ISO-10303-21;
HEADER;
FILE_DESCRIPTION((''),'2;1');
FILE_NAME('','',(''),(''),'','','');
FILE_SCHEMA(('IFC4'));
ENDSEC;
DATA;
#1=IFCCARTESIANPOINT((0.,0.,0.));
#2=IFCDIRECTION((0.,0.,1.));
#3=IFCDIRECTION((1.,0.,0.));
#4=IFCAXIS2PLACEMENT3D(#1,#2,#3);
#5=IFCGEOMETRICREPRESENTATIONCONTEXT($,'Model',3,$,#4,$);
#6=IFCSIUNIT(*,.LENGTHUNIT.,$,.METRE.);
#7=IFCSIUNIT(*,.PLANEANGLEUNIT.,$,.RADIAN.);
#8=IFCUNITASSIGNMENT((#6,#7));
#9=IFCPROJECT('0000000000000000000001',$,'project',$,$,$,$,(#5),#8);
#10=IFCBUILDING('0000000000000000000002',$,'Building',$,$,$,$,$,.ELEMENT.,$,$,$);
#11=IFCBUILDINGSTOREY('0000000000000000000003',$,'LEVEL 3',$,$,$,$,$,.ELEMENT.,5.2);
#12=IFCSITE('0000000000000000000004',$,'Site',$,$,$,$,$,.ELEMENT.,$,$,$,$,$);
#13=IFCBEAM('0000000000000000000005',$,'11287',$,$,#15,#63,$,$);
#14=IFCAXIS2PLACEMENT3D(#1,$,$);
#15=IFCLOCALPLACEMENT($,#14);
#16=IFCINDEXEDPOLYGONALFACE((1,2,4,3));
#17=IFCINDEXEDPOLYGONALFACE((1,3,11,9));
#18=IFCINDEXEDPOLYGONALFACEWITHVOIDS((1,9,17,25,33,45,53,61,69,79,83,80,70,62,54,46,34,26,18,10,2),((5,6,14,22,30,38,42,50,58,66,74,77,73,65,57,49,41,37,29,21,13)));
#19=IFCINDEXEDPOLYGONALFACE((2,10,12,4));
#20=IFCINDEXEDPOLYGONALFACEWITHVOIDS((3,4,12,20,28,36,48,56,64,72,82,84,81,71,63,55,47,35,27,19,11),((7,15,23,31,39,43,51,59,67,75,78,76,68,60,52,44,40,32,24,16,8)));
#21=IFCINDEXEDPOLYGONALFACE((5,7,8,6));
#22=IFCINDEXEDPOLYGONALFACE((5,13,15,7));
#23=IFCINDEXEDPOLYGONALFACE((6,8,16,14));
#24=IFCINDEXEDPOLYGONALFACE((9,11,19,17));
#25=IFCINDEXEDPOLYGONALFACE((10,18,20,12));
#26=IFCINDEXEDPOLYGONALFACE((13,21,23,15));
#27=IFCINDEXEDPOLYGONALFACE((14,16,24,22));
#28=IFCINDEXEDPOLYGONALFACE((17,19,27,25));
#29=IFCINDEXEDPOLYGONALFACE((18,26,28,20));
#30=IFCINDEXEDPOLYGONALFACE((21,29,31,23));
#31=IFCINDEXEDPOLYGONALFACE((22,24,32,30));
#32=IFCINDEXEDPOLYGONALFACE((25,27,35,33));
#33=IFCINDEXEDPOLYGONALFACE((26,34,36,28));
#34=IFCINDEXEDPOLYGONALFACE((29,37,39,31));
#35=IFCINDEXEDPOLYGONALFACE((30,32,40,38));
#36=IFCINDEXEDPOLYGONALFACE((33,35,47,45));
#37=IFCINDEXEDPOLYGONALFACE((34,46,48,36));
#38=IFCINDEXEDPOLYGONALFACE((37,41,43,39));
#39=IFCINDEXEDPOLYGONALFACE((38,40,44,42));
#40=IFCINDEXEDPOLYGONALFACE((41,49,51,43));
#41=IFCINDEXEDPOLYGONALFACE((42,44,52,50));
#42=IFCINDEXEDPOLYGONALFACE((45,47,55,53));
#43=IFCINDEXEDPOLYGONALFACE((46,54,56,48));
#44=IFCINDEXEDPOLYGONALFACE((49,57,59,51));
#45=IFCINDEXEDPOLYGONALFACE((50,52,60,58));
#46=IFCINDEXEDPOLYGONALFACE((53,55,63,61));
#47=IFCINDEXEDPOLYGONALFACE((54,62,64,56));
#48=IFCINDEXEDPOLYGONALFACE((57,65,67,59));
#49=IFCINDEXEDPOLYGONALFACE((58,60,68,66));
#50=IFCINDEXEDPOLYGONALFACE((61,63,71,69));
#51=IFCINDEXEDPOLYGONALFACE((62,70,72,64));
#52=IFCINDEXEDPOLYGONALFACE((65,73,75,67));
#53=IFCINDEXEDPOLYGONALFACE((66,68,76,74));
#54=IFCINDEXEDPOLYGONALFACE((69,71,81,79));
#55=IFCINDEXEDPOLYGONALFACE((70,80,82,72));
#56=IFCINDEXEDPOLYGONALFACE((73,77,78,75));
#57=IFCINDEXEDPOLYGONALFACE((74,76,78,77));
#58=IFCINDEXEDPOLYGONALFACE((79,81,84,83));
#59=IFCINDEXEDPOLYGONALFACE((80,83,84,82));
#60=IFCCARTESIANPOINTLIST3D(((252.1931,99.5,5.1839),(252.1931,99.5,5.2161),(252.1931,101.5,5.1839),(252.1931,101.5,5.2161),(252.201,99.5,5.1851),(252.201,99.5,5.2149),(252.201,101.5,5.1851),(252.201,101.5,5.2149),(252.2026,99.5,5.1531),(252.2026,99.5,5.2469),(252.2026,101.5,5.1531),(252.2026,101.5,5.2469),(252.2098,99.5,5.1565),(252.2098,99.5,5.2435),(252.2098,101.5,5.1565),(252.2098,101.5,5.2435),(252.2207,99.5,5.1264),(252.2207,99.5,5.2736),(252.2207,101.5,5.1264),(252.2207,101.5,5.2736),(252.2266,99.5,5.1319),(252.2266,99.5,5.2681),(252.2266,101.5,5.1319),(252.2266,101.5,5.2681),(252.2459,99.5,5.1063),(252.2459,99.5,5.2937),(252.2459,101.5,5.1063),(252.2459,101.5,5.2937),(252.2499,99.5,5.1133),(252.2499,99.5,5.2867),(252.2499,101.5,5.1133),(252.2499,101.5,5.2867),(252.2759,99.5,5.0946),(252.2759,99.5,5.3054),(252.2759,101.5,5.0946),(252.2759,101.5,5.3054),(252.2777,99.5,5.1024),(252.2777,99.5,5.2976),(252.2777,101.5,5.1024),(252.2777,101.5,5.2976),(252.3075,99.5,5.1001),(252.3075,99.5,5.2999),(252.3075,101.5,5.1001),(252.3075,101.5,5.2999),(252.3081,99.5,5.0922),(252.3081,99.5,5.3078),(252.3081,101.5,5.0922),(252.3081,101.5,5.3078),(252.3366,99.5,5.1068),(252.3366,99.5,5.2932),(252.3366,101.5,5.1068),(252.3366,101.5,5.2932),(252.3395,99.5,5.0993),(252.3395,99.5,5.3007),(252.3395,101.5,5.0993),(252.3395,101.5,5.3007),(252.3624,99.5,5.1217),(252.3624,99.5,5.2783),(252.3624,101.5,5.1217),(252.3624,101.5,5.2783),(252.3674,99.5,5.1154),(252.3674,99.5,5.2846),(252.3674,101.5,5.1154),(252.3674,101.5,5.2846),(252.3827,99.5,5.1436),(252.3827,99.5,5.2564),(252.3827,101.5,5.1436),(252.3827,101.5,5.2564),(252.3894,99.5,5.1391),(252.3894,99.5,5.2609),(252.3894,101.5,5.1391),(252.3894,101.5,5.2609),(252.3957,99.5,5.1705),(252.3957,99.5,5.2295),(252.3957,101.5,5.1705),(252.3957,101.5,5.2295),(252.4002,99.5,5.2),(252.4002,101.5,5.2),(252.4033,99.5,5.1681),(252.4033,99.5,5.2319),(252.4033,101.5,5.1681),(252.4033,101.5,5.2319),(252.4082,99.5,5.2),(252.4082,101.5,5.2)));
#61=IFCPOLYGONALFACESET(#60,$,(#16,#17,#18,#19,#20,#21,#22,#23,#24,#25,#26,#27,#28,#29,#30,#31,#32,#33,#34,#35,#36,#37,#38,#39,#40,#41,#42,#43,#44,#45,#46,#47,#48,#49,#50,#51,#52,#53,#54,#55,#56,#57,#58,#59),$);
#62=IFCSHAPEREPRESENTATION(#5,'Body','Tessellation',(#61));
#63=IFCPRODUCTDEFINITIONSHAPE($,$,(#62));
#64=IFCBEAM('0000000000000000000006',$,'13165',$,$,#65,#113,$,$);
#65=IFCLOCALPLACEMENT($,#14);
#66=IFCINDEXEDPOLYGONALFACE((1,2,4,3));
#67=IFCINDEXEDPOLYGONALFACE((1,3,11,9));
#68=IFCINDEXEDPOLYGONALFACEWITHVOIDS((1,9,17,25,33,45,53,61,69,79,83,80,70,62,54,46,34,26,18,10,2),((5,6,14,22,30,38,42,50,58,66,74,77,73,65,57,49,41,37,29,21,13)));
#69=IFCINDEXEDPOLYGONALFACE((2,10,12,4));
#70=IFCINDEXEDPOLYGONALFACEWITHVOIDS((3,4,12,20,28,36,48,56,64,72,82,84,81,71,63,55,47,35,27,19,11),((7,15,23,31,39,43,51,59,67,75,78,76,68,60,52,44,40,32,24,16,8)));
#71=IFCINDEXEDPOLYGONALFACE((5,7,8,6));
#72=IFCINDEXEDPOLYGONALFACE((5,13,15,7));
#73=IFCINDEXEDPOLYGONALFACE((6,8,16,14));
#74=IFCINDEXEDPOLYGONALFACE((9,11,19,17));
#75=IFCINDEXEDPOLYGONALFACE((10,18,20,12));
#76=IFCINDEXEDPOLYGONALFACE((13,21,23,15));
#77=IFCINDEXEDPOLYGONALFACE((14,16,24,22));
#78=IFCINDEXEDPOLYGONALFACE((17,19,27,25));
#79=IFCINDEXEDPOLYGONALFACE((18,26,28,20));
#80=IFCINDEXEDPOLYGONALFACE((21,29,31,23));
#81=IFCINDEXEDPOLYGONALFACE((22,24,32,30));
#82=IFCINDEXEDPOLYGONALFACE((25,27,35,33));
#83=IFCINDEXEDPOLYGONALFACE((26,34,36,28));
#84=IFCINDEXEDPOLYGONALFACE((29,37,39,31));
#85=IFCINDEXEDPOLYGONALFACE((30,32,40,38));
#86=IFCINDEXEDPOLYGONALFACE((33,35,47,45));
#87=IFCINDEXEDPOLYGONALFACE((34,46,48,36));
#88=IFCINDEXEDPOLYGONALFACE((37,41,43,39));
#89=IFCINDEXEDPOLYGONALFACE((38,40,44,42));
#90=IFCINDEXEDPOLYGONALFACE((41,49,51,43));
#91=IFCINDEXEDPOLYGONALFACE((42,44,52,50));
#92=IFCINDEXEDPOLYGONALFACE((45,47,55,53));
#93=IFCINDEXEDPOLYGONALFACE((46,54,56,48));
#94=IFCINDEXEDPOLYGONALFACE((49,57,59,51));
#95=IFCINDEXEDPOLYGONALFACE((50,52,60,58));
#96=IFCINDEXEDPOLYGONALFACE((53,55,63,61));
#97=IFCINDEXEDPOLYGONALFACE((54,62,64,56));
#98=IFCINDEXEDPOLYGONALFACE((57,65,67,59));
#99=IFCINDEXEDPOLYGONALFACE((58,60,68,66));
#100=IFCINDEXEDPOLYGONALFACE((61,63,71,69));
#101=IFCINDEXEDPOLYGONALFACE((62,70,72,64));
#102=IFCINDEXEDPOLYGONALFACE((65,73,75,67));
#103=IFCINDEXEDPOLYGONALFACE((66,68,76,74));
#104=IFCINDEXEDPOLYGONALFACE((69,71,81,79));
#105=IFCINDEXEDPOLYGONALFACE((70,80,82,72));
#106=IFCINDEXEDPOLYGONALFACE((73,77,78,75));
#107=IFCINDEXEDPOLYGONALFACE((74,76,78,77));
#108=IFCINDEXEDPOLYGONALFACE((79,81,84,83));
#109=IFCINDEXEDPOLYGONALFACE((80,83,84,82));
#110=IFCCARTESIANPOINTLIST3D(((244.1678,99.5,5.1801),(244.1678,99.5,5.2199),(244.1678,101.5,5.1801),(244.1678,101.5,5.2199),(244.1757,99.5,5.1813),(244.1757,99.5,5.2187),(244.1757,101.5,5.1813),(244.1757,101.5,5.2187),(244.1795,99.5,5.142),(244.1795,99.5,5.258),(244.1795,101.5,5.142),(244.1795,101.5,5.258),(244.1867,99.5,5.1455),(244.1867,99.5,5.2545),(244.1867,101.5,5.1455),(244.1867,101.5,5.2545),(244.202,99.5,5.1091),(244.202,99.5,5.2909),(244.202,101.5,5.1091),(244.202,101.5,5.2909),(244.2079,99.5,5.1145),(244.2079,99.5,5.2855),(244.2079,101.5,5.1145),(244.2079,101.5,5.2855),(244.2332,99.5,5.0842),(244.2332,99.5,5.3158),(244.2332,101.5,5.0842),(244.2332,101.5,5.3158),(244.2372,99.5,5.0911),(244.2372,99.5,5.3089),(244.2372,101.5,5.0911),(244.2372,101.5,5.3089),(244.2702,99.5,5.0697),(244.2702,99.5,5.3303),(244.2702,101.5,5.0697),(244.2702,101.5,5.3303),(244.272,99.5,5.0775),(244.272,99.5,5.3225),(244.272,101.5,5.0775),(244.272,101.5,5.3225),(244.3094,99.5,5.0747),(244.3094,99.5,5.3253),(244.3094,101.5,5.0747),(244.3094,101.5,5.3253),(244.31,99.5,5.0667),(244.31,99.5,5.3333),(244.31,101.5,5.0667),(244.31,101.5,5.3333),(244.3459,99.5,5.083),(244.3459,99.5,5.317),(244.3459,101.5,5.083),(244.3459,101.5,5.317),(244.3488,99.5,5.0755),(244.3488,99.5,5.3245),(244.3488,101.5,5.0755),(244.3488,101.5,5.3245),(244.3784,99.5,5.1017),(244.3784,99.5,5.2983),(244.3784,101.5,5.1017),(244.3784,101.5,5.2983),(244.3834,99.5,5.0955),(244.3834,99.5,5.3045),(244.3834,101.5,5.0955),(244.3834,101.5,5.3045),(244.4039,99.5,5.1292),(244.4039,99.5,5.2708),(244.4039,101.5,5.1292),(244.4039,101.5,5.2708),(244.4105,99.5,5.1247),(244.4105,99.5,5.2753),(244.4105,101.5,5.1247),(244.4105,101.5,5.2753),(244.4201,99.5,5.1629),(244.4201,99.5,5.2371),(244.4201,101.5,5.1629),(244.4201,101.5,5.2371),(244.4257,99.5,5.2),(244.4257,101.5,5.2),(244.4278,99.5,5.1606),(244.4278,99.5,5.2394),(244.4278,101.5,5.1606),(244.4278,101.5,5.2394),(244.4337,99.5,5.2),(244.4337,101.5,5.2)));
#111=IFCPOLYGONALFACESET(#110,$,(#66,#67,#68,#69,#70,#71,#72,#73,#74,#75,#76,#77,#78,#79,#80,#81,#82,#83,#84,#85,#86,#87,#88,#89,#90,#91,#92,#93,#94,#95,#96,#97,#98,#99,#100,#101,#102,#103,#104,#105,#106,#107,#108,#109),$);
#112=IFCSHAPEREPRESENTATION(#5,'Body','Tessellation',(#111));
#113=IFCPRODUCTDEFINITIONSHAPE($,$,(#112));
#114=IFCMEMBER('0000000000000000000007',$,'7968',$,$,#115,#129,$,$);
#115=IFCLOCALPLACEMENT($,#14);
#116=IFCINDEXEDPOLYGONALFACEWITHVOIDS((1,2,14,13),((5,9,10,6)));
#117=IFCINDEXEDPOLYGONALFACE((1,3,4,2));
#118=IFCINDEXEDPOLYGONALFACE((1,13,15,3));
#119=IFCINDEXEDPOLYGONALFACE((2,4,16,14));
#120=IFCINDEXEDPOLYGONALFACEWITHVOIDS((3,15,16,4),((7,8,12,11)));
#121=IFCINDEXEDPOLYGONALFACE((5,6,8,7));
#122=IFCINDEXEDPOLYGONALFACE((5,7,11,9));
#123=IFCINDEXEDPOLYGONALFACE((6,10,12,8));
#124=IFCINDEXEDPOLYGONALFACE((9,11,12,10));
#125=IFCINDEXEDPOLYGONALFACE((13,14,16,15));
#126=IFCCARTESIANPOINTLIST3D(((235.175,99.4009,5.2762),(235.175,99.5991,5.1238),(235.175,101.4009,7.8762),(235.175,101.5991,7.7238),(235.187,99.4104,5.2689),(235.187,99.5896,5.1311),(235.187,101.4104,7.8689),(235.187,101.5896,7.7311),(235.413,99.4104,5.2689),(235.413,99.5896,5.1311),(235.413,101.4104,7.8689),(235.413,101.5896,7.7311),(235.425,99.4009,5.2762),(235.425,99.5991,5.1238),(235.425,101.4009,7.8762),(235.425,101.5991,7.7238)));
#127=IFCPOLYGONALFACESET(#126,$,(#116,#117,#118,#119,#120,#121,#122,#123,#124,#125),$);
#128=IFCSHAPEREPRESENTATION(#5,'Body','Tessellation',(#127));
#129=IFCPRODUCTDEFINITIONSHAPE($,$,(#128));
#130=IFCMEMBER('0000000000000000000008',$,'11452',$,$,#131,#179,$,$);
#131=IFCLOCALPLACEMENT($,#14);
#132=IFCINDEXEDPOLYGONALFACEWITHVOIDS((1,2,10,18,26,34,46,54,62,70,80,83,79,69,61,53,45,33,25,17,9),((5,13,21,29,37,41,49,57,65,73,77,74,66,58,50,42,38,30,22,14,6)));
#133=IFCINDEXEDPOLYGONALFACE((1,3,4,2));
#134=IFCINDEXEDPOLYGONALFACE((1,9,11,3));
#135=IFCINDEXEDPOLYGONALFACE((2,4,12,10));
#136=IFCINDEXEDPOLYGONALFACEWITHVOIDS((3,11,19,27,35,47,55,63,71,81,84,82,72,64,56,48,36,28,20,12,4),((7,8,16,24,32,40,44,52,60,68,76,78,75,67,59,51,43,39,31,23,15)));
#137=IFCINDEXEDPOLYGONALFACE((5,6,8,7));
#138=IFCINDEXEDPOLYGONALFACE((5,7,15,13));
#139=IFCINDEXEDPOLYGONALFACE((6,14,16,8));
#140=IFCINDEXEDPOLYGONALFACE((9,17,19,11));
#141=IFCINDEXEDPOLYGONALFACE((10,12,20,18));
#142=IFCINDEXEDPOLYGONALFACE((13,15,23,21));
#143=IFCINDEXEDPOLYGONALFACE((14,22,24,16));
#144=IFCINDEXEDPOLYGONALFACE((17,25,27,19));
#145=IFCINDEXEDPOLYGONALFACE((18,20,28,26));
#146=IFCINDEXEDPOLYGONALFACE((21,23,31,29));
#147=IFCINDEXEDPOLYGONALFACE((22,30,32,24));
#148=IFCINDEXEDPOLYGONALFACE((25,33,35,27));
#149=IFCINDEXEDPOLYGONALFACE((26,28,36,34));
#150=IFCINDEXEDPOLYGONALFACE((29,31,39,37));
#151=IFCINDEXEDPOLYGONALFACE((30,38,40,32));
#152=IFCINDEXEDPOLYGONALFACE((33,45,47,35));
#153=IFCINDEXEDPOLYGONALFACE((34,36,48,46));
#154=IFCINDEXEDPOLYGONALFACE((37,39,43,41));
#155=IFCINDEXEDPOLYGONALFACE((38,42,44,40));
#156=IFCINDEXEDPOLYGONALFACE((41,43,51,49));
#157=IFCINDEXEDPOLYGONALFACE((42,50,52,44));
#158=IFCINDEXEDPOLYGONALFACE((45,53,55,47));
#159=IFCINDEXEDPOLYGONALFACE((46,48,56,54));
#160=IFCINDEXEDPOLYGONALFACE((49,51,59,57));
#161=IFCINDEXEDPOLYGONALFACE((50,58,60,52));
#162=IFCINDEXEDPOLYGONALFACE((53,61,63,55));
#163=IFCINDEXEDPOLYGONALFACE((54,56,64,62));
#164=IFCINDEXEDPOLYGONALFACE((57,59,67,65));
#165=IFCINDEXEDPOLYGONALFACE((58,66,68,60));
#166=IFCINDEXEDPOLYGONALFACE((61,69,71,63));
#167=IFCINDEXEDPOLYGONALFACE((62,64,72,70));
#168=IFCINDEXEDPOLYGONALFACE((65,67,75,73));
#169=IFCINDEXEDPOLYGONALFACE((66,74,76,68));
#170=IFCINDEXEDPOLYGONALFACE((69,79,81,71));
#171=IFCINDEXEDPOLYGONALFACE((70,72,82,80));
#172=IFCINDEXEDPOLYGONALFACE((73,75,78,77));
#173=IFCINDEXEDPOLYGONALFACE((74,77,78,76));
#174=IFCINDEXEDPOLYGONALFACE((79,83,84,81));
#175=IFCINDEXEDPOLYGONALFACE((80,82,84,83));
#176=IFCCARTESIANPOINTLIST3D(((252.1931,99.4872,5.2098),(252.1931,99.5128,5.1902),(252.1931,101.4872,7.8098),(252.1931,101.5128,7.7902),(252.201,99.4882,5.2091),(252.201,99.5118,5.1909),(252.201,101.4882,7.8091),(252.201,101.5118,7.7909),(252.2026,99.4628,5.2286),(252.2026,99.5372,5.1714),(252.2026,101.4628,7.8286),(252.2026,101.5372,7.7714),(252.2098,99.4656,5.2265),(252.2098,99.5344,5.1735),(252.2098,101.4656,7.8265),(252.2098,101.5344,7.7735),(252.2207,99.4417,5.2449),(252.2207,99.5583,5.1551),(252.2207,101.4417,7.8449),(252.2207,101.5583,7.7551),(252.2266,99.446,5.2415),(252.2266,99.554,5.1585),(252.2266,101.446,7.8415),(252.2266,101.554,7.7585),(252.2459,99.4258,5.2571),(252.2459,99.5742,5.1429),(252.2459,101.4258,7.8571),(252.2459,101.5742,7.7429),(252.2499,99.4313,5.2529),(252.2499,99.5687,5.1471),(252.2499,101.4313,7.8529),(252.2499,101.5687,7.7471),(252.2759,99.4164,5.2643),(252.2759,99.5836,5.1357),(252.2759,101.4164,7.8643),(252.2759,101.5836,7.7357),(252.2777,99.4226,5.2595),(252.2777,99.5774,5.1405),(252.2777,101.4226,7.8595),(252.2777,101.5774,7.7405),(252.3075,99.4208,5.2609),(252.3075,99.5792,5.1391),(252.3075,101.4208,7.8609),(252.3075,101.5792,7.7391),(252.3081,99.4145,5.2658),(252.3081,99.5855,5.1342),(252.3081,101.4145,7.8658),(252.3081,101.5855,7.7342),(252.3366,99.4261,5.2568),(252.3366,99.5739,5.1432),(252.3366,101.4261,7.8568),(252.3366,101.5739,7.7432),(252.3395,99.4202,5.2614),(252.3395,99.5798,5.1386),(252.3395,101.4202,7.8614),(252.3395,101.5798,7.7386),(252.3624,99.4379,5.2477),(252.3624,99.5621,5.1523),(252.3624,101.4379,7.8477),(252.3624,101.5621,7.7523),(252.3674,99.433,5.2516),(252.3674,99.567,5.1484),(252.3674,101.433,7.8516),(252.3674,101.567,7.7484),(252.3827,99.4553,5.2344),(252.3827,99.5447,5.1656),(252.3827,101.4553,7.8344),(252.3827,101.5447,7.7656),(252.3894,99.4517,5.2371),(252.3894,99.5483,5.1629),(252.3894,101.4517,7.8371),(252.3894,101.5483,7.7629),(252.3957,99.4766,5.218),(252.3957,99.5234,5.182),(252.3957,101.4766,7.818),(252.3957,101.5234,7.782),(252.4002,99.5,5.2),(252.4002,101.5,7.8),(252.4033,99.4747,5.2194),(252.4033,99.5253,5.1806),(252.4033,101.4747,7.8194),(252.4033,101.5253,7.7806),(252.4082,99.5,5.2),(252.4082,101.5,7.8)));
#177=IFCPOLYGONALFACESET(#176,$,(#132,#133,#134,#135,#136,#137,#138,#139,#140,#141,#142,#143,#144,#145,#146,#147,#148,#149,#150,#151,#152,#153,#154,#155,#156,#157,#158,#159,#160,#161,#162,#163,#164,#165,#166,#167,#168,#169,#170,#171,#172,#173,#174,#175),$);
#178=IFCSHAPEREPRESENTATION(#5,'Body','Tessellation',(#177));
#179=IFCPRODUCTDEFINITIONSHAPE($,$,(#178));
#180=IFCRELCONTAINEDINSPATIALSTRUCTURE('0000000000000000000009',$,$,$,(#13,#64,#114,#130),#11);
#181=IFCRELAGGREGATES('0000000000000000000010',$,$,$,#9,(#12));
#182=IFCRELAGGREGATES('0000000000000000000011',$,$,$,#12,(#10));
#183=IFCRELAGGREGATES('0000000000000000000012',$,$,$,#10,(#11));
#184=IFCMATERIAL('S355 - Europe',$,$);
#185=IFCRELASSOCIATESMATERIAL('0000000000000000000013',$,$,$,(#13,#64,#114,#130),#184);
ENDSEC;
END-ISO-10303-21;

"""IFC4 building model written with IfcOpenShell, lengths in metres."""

from ifc_helpers import new_model, si_unit, frame, origin_with_axes, origin_2d_with_axis, place, context, project, spatial, hollow_rectangle, hollow_circle, extrude, material, material_profile, profile_set, profile_usage, element, save


model = new_model("IFC4")

# Units and contexts
model_context = context("Model", 3, world=origin_with_axes())
ifc_project = project(units=[si_unit("LENGTHUNIT", "METRE"), si_unit("PLANEANGLEUNIT", "RADIAN")], contexts=[model_context])

# Site, building, storey
site = spatial("IfcSite", under=ifc_project, Name="Site", CompositionType="ELEMENT")
building = spatial("IfcBuilding", under=site, Name="Building", CompositionType="ELEMENT")
storey = spatial("IfcBuildingStorey", under=building, Name="LEVEL 3", CompositionType="ELEMENT", Elevation=5.2)

# Shared definitions
ifc_material = material(Name="S355 - Europe")

# Beams
ifc_material_profile_1 = material_profile(ifc_material, hollow_circle(Radius=0.1081, WallThickness=0.008, at=origin_2d_with_axis()))
ifc_profile_set_1 = profile_set([ifc_material_profile_1])
ifc_profile_usage_1 = profile_usage(ifc_profile_set_1, cardinal=10)
beam_1_placement = place(None, frame((252.3, 101.5, 5.2), z_axis=(0.0, -1.0, 0.0), x_axis=(1.0, 0.0, 0.0)))
element("IfcBeam", 1, at=beam_1_placement, inside=storey, material=ifc_profile_usage_1, Name="11287", context=model_context, shape_type="SweptSolid", body=[
    extrude(hollow_circle(Radius=0.1081, WallThickness=0.008, at=origin_2d_with_axis()), origin_with_axes(), (0.0, 0.0, 1.0), 2.0),
])
ifc_material_profile_2 = material_profile(ifc_material, hollow_circle(Radius=0.1337, WallThickness=0.008, at=origin_2d_with_axis()))
ifc_profile_set_2 = profile_set([ifc_material_profile_2])
ifc_profile_usage_2 = profile_usage(ifc_profile_set_2, cardinal=10)
beam_2_placement = place(None, frame((244.3, 101.5, 5.2), z_axis=(0.0, -1.0, 0.0), x_axis=(1.0, 0.0, 0.0)))
element("IfcBeam", 2, at=beam_2_placement, inside=storey, material=ifc_profile_usage_2, Name="13165", context=model_context, shape_type="SweptSolid", body=[
    extrude(hollow_circle(Radius=0.1337, WallThickness=0.008, at=origin_2d_with_axis()), origin_with_axes(), (0.0, 0.0, 1.0), 2.0),
])

# Members
ifc_material_profile_3 = material_profile(ifc_material, hollow_rectangle(XDim=0.25, YDim=0.25, WallThickness=0.012, at=origin_2d_with_axis()))
ifc_profile_set_3 = profile_set([ifc_material_profile_3])
ifc_profile_usage_3 = profile_usage(ifc_profile_set_3, cardinal=10)
member_1_placement = place(None, frame((235.3, 101.5, 7.8), z_axis=(0.0, -0.609711, -0.792624), x_axis=(1.0, 0.0, 0.0)))
element("IfcMember", 3, at=member_1_placement, inside=storey, material=ifc_profile_usage_3, Name="7968", context=model_context, shape_type="SweptSolid", body=[
    extrude(hollow_rectangle(XDim=0.25, YDim=0.25, WallThickness=0.012, at=origin_2d_with_axis()), origin_with_axes(), (0.0, 0.0, 1.0), 3.2802),
])
ifc_material_profile_4 = material_profile(ifc_material, hollow_circle(Radius=0.1081, WallThickness=0.008, at=origin_2d_with_axis()))
ifc_profile_set_4 = profile_set([ifc_material_profile_4])
ifc_profile_usage_4 = profile_usage(ifc_profile_set_4, cardinal=10)
member_2_placement = place(None, frame((252.3, 101.5, 7.8), z_axis=(0.0, -0.609711, -0.792624), x_axis=(1.0, 0.0, 0.0)))
element("IfcMember", 4, at=member_2_placement, inside=storey, material=ifc_profile_usage_4, Name="11452", context=model_context, shape_type="SweptSolid", body=[
    extrude(hollow_circle(Radius=0.1081, WallThickness=0.008, at=origin_2d_with_axis()), origin_with_axes(), (0.0, 0.0, 1.0), 3.2802),
])

save(model, "model.ifc")
